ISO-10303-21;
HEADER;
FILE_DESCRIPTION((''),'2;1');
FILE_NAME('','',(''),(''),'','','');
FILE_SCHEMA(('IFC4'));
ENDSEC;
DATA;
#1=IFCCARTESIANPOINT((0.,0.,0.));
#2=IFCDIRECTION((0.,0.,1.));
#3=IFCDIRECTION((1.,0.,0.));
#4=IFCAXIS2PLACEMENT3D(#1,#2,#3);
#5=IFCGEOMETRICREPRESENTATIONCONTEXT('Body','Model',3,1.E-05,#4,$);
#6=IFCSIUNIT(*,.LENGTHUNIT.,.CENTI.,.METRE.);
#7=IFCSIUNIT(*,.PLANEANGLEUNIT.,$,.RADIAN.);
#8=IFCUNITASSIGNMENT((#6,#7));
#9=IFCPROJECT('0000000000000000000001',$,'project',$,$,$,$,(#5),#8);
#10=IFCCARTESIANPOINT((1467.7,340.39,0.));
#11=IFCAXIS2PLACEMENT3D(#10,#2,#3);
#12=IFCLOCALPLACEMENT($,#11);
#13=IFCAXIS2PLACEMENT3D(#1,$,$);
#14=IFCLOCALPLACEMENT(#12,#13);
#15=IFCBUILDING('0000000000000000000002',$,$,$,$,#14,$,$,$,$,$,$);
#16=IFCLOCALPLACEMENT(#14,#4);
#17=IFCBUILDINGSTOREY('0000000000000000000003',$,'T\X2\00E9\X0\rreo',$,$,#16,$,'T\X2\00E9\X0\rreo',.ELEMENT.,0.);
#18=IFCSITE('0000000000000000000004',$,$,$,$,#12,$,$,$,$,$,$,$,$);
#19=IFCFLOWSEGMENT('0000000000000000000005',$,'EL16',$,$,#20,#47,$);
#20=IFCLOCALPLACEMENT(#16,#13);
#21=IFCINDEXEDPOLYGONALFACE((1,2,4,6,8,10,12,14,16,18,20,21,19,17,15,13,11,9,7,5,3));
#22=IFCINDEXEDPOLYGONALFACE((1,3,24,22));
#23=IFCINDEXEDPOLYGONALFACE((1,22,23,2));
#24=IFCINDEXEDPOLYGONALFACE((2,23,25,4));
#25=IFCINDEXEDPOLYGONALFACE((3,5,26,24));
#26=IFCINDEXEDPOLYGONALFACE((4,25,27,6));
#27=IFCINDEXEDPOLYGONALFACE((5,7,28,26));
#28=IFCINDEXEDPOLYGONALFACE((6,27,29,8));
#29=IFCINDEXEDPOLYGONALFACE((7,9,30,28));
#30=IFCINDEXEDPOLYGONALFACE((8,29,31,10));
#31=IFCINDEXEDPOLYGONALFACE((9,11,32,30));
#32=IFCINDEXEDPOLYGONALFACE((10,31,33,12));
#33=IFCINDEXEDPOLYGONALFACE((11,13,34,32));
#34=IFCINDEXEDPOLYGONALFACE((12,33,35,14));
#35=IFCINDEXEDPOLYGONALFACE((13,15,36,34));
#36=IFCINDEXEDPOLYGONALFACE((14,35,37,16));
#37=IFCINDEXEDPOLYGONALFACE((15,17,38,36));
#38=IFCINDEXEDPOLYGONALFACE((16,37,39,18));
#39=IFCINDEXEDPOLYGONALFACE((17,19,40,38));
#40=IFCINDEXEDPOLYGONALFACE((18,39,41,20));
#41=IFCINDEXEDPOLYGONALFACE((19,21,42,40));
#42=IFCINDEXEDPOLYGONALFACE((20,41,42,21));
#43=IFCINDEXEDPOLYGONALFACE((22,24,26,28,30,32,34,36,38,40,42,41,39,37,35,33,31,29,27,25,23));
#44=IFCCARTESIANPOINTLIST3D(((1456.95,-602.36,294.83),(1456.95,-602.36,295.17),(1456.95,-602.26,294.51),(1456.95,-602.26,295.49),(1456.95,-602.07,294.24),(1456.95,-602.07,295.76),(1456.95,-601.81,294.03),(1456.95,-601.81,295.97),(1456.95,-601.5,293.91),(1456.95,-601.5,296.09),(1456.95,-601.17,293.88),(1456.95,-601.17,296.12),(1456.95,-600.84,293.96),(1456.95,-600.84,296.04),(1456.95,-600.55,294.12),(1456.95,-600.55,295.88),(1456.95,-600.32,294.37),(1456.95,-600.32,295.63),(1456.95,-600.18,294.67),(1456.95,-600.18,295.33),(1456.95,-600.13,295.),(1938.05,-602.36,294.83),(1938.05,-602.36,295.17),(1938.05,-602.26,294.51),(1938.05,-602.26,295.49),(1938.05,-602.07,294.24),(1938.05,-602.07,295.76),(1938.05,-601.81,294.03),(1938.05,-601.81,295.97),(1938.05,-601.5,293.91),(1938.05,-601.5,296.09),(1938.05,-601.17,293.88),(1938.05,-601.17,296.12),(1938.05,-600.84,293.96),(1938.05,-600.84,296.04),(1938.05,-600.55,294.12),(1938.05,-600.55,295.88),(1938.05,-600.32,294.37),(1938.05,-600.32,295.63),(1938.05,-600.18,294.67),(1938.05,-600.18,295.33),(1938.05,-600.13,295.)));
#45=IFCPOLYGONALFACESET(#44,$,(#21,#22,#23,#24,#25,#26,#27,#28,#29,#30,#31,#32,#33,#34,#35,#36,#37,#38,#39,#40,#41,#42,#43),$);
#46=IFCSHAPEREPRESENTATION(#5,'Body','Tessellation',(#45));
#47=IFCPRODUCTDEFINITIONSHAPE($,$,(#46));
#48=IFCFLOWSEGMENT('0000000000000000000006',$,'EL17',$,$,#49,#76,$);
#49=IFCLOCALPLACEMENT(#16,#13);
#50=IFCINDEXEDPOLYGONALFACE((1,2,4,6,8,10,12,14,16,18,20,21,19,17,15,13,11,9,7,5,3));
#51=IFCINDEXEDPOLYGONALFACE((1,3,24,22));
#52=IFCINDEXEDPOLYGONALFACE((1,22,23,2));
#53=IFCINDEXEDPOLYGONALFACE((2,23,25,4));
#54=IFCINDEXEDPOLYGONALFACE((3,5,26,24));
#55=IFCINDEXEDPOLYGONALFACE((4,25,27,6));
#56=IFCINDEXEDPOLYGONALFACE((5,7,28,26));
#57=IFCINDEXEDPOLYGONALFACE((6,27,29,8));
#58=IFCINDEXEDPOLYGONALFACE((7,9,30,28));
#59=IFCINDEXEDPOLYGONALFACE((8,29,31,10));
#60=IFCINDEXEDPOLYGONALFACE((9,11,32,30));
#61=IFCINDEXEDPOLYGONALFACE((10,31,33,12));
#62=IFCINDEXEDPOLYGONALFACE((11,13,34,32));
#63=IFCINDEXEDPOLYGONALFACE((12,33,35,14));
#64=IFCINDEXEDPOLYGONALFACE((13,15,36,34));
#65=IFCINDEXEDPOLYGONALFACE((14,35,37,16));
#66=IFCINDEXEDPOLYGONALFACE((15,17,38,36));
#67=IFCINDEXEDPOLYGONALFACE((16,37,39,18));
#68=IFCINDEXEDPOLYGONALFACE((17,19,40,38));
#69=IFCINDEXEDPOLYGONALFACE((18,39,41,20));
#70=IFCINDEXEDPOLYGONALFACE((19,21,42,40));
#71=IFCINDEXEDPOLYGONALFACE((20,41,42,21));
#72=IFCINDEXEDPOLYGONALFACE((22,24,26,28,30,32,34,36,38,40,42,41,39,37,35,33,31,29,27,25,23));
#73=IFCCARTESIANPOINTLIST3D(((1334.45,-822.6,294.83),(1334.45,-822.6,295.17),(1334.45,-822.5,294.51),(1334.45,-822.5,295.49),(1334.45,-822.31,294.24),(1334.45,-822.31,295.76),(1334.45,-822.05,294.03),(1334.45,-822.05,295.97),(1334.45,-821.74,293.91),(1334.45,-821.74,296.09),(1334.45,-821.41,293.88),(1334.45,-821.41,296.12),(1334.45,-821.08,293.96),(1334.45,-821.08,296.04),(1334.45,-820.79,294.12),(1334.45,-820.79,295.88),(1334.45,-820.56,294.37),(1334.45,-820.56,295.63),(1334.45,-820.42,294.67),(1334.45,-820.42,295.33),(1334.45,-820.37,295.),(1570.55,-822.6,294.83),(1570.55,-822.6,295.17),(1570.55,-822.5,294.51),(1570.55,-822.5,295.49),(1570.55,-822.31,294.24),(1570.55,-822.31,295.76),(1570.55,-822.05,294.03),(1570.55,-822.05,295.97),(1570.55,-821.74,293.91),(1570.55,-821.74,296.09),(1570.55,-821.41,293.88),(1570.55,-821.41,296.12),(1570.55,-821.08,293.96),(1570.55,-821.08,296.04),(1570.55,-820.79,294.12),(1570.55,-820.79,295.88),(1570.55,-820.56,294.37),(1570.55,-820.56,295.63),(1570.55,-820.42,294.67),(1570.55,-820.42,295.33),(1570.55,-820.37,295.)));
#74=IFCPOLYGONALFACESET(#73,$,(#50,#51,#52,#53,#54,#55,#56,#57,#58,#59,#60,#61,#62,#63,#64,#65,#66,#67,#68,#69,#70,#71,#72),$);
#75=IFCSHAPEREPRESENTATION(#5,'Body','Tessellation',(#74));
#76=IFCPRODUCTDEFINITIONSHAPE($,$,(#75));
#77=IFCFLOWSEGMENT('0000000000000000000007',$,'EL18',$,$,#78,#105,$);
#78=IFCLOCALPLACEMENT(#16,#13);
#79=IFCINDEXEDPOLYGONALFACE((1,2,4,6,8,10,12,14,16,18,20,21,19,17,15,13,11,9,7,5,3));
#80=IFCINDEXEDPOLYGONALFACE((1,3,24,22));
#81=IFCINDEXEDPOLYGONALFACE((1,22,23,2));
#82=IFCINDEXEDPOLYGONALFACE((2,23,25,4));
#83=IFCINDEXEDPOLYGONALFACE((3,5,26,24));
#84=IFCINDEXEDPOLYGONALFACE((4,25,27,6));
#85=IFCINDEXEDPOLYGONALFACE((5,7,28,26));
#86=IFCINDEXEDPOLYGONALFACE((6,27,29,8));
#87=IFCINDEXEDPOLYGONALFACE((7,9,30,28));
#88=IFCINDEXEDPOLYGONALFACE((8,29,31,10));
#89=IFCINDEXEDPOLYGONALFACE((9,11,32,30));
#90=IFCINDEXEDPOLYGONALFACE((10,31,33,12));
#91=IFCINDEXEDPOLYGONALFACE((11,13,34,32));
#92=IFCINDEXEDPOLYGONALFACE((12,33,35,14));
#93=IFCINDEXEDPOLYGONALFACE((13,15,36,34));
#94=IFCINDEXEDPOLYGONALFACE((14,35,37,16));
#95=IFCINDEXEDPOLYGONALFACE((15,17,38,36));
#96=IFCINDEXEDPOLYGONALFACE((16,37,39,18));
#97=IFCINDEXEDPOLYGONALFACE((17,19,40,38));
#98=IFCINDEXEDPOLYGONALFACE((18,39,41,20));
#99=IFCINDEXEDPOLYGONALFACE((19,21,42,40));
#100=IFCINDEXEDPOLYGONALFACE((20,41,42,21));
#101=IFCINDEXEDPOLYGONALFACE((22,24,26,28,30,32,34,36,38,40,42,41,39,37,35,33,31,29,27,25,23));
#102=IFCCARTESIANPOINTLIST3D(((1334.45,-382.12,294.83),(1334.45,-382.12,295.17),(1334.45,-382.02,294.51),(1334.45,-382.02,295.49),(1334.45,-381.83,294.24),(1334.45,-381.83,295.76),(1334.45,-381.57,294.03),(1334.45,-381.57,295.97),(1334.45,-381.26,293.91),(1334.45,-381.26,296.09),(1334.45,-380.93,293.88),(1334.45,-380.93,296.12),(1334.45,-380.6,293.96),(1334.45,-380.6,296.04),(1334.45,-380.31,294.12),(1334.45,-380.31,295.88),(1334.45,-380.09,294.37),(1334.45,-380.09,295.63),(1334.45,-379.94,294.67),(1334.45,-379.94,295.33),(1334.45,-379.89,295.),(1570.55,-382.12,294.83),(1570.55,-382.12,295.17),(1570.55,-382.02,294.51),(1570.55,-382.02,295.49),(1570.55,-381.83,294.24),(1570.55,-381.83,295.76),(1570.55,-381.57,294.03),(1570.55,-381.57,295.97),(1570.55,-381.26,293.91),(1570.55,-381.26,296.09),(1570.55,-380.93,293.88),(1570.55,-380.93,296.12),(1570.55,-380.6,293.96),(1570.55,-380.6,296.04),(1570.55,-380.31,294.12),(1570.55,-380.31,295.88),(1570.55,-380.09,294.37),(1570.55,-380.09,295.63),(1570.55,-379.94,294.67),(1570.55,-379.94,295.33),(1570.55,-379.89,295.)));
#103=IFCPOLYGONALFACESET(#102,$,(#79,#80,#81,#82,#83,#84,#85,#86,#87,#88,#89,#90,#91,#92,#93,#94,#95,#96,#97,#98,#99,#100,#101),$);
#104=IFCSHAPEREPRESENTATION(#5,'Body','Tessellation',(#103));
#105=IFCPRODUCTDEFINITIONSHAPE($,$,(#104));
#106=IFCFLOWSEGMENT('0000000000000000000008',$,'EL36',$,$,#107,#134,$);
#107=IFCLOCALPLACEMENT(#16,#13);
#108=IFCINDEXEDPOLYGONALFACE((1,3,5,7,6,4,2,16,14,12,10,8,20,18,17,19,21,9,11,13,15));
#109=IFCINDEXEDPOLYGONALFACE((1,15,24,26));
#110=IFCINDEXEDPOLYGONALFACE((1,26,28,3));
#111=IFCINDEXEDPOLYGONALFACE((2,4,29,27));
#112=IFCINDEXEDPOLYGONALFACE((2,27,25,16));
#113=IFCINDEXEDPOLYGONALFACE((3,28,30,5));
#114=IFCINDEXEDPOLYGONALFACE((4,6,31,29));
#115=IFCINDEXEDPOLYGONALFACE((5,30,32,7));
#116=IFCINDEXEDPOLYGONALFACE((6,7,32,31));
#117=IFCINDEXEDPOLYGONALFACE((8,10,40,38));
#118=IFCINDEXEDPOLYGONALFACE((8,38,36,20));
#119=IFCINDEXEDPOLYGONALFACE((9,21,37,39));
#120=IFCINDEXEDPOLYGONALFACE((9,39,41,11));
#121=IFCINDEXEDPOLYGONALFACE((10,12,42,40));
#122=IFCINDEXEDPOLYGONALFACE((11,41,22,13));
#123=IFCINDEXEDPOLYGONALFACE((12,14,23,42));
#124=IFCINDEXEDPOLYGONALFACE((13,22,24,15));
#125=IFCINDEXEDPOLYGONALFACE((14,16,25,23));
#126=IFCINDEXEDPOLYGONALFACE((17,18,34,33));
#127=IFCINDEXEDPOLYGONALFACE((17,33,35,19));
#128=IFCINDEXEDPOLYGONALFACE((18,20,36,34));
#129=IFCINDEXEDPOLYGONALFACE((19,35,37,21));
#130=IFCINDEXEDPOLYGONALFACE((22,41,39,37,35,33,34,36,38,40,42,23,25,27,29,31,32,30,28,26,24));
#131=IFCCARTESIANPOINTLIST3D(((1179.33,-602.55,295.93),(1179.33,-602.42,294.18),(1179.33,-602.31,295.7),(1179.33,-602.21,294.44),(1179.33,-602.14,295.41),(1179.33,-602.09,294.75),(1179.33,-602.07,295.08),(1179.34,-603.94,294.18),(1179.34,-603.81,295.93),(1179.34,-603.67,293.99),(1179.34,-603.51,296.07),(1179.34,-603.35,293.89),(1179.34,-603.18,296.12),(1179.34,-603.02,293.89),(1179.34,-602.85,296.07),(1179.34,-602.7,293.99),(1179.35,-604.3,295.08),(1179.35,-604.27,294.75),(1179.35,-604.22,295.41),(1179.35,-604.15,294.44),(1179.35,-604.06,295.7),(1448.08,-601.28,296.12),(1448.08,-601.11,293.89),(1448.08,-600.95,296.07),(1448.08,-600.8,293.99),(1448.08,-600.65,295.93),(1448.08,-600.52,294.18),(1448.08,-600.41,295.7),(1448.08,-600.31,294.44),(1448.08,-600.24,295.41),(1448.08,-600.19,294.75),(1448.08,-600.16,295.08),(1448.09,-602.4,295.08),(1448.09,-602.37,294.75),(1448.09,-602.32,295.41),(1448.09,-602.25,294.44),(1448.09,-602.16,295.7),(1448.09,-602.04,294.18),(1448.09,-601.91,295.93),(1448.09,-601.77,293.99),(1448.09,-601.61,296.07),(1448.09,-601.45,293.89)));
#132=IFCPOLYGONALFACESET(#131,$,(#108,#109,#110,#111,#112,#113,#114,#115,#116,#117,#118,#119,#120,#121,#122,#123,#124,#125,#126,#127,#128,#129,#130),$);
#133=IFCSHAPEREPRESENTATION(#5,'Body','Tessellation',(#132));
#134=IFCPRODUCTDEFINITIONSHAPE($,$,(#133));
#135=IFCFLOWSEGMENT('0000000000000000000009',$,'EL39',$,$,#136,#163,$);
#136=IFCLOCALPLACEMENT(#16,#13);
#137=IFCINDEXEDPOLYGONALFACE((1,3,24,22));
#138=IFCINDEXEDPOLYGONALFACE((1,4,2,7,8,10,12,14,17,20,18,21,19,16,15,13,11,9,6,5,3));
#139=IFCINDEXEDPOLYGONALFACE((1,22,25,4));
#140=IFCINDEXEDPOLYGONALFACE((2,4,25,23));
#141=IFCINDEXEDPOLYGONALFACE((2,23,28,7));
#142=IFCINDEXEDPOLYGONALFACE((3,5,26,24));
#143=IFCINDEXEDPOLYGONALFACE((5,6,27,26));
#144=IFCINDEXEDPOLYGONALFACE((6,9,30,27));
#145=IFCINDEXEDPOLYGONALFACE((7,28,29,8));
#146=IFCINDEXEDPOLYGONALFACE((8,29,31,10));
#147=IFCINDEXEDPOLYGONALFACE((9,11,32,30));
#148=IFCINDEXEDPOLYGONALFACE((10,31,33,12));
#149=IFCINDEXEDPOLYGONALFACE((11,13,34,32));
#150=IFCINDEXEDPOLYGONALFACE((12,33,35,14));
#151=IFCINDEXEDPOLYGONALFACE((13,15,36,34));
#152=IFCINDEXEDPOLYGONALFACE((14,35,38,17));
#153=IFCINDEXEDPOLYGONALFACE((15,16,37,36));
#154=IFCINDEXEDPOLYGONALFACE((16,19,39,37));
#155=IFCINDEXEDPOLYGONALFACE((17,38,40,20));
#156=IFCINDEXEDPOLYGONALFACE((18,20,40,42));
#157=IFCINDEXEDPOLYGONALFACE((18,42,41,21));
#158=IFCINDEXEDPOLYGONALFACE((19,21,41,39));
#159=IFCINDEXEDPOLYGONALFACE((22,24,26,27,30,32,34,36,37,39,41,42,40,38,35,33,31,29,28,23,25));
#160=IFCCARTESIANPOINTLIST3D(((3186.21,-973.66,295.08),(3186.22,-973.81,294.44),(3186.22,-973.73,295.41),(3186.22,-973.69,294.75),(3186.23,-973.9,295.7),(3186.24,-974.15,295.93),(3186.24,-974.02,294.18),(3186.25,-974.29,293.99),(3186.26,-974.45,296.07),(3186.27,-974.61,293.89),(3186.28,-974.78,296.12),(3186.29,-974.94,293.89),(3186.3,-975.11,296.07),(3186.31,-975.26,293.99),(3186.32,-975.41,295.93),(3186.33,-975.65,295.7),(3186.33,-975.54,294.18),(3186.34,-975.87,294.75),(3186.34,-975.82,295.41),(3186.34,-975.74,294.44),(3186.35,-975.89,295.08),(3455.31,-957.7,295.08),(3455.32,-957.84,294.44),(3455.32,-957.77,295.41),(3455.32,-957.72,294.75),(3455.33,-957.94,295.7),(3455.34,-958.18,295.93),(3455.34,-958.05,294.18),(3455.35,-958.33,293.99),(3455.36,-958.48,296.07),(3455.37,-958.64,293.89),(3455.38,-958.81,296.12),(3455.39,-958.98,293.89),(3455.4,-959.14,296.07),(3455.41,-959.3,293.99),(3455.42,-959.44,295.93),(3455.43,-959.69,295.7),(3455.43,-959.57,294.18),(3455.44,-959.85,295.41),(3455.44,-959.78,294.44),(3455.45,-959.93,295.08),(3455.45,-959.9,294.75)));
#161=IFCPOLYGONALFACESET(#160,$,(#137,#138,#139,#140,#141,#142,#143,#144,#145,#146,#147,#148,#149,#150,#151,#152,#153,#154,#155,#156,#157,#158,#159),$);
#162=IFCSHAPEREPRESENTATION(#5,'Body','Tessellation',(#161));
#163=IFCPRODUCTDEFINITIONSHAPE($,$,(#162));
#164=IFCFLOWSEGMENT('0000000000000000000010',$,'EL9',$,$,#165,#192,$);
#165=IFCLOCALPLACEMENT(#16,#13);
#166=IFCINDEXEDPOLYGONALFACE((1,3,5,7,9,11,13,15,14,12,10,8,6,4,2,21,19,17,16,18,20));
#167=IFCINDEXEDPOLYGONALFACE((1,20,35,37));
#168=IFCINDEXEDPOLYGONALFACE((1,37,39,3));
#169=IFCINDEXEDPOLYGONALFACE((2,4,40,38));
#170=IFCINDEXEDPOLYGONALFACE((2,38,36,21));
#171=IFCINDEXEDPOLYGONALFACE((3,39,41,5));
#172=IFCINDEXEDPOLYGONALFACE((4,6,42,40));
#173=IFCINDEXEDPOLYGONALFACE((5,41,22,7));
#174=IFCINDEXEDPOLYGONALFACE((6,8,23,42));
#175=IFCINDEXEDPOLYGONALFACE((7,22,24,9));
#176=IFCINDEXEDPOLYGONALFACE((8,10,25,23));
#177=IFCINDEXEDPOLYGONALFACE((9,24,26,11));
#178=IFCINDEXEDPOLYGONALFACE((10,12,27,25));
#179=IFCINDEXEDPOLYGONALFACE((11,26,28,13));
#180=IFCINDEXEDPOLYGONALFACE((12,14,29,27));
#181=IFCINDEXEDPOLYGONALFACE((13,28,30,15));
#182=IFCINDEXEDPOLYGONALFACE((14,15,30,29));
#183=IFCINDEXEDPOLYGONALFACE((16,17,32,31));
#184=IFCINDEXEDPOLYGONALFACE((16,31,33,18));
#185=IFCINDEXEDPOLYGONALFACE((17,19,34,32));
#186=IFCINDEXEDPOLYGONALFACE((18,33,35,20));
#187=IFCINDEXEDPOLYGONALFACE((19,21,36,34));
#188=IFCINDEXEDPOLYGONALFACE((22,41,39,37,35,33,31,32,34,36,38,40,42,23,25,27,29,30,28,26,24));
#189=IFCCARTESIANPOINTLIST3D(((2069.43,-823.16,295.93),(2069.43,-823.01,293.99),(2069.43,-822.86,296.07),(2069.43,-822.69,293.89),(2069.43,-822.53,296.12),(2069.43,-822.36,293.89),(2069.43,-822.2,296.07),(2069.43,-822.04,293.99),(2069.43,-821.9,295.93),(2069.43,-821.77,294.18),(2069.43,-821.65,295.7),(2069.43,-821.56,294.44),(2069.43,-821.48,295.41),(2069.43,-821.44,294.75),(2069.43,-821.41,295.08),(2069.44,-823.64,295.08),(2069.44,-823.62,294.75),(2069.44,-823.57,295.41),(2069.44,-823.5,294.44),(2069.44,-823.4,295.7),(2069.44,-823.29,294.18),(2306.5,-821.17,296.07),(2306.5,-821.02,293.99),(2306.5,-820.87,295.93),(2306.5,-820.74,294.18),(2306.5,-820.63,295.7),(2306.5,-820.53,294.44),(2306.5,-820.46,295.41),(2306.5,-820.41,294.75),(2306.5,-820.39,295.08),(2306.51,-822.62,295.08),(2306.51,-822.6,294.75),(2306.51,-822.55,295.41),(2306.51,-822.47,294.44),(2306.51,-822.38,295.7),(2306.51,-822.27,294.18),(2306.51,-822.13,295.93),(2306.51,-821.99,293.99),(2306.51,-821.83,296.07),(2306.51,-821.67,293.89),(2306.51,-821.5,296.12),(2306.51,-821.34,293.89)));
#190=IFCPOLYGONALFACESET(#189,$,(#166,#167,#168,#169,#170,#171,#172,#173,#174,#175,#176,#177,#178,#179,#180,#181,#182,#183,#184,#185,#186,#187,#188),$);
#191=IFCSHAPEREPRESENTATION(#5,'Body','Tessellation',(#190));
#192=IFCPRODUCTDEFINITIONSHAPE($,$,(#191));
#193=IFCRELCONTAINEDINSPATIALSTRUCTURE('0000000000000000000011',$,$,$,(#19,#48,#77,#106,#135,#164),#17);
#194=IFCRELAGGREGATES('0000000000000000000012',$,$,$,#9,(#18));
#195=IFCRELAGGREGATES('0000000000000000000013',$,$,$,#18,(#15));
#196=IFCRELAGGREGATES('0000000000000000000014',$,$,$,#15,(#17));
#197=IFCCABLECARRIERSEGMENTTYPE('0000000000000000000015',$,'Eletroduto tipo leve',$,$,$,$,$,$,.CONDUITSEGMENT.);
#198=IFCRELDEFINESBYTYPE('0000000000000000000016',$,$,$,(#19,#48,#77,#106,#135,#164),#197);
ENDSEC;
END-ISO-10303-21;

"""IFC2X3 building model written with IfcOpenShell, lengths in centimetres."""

from ifc_helpers import new_model, si_unit, frame, origin, origin_with_axes, origin_2d_with_axis, place, context, project, spatial, circle, extrude, type_object, element, save


model = new_model("IFC2X3")

# Units and contexts
model_context = context("Model", 3, precision=1e-05, world=origin_with_axes(), identifier="Body")
ifc_project = project(units=[si_unit("LENGTHUNIT", "METRE", prefix="CENTI"), si_unit("PLANEANGLEUNIT", "RADIAN")], contexts=[model_context])

# Site, building, storey
site_placement = place(None, frame((1467.7, 340.39, 0.0), z_axis=(0.0, 0.0, 1.0), x_axis=(1.0, 0.0, 0.0)))
site = spatial("IfcSite", under=ifc_project, at=site_placement)
building_placement = place(site_placement, origin())
building = spatial("IfcBuilding", under=site, at=building_placement)
storey_placement = place(building_placement, origin_with_axes())
storey = spatial("IfcBuildingStorey", under=building, at=storey_placement, Name="Térreo", LongName="Térreo", CompositionType="ELEMENT", Elevation=0.0)

# Flow segments
cable_carrier_segment_type = type_object("IfcCableCarrierSegmentType", Name="Eletroduto tipo leve", PredefinedType="CONDUITSEGMENT")
flow_segment_1_placement = place(storey_placement, frame((1697.5, -601.25, 296.12), z_axis=(0.0, 0.0, 1.0), x_axis=(1.0, 0.0, 0.0)))
element("IfcFlowSegment", 1, at=flow_segment_1_placement, inside=storey, type_object=cable_carrier_segment_type, Name="EL16", context=model_context, shape_type="SolidModel", body=[
    extrude(circle(Radius=1.12, at=origin_2d_with_axis()), frame((240.55, 0.0, -1.12), z_axis=(-1.0, 0.0, 0.0), x_axis=(0.0, 1.0, 0.0)), (0.0, 0.0, 1.0), 481.1),
])
flow_segment_2_placement = place(storey_placement, frame((1452.5, -821.49, 296.12), z_axis=(0.0, 0.0, 1.0), x_axis=(1.0, 0.0, 0.0)))
element("IfcFlowSegment", 2, at=flow_segment_2_placement, inside=storey, type_object=cable_carrier_segment_type, Name="EL17", context=model_context, shape_type="SolidModel", body=[
    extrude(circle(Radius=1.12, at=origin_2d_with_axis()), frame((118.05, 0.0, -1.12), z_axis=(-1.0, 0.0, 0.0), x_axis=(0.0, 1.0, 0.0)), (0.0, 0.0, 1.0), 236.1),
])
flow_segment_3_placement = place(storey_placement, frame((1452.5, -381.01, 296.12), z_axis=(0.0, 0.0, 1.0), x_axis=(1.0, 0.0, 0.0)))
element("IfcFlowSegment", 3, at=flow_segment_3_placement, inside=storey, type_object=cable_carrier_segment_type, Name="EL18", context=model_context, shape_type="SolidModel", body=[
    extrude(circle(Radius=1.12, at=origin_2d_with_axis()), frame((118.05, 0.0, -1.12), z_axis=(-1.0, 0.0, 0.0), x_axis=(0.0, 1.0, 0.0)), (0.0, 0.0, 1.0), 236.1),
])
flow_segment_4_placement = place(storey_placement, frame((1313.71, -602.23, 296.12), z_axis=(0.0, 0.0, 1.0), x_axis=(1.0, 0.0, 0.0)))
element("IfcFlowSegment", 4, at=flow_segment_4_placement, inside=storey, type_object=cable_carrier_segment_type, Name="EL36", context=model_context, shape_type="SolidModel", body=[
    extrude(circle(Radius=1.12, at=origin_2d_with_axis()), frame((-134.37, -0.95, -1.12), z_axis=(1.0, 0.007072, 0.0), x_axis=(0.0, 0.0, 1.0)), (0.0, 0.0, 1.0), 268.75),
])
flow_segment_5_placement = place(storey_placement, frame((3320.83, -966.79, 296.12), z_axis=(0.0, 0.0, 1.0), x_axis=(1.0, 0.0, 0.0)))
element("IfcFlowSegment", 5, at=flow_segment_5_placement, inside=storey, type_object=cable_carrier_segment_type, Name="EL39", context=model_context, shape_type="SolidModel", body=[
    extrude(circle(Radius=1.12, at=origin_2d_with_axis()), frame((134.55, 7.98, -1.12), z_axis=(-0.998245, -0.059222, 0.0), x_axis=(0.0, 0.0, 1.0)), (0.0, 0.0, 1.0), 269.57),
])
flow_segment_6_placement = place(storey_placement, frame((2187.97, -822.02, 296.12), z_axis=(0.0, 0.0, 1.0), x_axis=(1.0, 0.0, 0.0)))
element("IfcFlowSegment", 6, at=flow_segment_6_placement, inside=storey, type_object=cable_carrier_segment_type, Name="EL9", context=model_context, shape_type="SolidModel", body=[
    extrude(circle(Radius=1.12, at=origin_2d_with_axis()), frame((118.54, 0.51, -1.12), z_axis=(-1.0, -0.004317, 0.0), x_axis=(0.0, 0.0, 1.0)), (0.0, 0.0, 1.0), 237.08),
])

save(model, "model.ifc")
